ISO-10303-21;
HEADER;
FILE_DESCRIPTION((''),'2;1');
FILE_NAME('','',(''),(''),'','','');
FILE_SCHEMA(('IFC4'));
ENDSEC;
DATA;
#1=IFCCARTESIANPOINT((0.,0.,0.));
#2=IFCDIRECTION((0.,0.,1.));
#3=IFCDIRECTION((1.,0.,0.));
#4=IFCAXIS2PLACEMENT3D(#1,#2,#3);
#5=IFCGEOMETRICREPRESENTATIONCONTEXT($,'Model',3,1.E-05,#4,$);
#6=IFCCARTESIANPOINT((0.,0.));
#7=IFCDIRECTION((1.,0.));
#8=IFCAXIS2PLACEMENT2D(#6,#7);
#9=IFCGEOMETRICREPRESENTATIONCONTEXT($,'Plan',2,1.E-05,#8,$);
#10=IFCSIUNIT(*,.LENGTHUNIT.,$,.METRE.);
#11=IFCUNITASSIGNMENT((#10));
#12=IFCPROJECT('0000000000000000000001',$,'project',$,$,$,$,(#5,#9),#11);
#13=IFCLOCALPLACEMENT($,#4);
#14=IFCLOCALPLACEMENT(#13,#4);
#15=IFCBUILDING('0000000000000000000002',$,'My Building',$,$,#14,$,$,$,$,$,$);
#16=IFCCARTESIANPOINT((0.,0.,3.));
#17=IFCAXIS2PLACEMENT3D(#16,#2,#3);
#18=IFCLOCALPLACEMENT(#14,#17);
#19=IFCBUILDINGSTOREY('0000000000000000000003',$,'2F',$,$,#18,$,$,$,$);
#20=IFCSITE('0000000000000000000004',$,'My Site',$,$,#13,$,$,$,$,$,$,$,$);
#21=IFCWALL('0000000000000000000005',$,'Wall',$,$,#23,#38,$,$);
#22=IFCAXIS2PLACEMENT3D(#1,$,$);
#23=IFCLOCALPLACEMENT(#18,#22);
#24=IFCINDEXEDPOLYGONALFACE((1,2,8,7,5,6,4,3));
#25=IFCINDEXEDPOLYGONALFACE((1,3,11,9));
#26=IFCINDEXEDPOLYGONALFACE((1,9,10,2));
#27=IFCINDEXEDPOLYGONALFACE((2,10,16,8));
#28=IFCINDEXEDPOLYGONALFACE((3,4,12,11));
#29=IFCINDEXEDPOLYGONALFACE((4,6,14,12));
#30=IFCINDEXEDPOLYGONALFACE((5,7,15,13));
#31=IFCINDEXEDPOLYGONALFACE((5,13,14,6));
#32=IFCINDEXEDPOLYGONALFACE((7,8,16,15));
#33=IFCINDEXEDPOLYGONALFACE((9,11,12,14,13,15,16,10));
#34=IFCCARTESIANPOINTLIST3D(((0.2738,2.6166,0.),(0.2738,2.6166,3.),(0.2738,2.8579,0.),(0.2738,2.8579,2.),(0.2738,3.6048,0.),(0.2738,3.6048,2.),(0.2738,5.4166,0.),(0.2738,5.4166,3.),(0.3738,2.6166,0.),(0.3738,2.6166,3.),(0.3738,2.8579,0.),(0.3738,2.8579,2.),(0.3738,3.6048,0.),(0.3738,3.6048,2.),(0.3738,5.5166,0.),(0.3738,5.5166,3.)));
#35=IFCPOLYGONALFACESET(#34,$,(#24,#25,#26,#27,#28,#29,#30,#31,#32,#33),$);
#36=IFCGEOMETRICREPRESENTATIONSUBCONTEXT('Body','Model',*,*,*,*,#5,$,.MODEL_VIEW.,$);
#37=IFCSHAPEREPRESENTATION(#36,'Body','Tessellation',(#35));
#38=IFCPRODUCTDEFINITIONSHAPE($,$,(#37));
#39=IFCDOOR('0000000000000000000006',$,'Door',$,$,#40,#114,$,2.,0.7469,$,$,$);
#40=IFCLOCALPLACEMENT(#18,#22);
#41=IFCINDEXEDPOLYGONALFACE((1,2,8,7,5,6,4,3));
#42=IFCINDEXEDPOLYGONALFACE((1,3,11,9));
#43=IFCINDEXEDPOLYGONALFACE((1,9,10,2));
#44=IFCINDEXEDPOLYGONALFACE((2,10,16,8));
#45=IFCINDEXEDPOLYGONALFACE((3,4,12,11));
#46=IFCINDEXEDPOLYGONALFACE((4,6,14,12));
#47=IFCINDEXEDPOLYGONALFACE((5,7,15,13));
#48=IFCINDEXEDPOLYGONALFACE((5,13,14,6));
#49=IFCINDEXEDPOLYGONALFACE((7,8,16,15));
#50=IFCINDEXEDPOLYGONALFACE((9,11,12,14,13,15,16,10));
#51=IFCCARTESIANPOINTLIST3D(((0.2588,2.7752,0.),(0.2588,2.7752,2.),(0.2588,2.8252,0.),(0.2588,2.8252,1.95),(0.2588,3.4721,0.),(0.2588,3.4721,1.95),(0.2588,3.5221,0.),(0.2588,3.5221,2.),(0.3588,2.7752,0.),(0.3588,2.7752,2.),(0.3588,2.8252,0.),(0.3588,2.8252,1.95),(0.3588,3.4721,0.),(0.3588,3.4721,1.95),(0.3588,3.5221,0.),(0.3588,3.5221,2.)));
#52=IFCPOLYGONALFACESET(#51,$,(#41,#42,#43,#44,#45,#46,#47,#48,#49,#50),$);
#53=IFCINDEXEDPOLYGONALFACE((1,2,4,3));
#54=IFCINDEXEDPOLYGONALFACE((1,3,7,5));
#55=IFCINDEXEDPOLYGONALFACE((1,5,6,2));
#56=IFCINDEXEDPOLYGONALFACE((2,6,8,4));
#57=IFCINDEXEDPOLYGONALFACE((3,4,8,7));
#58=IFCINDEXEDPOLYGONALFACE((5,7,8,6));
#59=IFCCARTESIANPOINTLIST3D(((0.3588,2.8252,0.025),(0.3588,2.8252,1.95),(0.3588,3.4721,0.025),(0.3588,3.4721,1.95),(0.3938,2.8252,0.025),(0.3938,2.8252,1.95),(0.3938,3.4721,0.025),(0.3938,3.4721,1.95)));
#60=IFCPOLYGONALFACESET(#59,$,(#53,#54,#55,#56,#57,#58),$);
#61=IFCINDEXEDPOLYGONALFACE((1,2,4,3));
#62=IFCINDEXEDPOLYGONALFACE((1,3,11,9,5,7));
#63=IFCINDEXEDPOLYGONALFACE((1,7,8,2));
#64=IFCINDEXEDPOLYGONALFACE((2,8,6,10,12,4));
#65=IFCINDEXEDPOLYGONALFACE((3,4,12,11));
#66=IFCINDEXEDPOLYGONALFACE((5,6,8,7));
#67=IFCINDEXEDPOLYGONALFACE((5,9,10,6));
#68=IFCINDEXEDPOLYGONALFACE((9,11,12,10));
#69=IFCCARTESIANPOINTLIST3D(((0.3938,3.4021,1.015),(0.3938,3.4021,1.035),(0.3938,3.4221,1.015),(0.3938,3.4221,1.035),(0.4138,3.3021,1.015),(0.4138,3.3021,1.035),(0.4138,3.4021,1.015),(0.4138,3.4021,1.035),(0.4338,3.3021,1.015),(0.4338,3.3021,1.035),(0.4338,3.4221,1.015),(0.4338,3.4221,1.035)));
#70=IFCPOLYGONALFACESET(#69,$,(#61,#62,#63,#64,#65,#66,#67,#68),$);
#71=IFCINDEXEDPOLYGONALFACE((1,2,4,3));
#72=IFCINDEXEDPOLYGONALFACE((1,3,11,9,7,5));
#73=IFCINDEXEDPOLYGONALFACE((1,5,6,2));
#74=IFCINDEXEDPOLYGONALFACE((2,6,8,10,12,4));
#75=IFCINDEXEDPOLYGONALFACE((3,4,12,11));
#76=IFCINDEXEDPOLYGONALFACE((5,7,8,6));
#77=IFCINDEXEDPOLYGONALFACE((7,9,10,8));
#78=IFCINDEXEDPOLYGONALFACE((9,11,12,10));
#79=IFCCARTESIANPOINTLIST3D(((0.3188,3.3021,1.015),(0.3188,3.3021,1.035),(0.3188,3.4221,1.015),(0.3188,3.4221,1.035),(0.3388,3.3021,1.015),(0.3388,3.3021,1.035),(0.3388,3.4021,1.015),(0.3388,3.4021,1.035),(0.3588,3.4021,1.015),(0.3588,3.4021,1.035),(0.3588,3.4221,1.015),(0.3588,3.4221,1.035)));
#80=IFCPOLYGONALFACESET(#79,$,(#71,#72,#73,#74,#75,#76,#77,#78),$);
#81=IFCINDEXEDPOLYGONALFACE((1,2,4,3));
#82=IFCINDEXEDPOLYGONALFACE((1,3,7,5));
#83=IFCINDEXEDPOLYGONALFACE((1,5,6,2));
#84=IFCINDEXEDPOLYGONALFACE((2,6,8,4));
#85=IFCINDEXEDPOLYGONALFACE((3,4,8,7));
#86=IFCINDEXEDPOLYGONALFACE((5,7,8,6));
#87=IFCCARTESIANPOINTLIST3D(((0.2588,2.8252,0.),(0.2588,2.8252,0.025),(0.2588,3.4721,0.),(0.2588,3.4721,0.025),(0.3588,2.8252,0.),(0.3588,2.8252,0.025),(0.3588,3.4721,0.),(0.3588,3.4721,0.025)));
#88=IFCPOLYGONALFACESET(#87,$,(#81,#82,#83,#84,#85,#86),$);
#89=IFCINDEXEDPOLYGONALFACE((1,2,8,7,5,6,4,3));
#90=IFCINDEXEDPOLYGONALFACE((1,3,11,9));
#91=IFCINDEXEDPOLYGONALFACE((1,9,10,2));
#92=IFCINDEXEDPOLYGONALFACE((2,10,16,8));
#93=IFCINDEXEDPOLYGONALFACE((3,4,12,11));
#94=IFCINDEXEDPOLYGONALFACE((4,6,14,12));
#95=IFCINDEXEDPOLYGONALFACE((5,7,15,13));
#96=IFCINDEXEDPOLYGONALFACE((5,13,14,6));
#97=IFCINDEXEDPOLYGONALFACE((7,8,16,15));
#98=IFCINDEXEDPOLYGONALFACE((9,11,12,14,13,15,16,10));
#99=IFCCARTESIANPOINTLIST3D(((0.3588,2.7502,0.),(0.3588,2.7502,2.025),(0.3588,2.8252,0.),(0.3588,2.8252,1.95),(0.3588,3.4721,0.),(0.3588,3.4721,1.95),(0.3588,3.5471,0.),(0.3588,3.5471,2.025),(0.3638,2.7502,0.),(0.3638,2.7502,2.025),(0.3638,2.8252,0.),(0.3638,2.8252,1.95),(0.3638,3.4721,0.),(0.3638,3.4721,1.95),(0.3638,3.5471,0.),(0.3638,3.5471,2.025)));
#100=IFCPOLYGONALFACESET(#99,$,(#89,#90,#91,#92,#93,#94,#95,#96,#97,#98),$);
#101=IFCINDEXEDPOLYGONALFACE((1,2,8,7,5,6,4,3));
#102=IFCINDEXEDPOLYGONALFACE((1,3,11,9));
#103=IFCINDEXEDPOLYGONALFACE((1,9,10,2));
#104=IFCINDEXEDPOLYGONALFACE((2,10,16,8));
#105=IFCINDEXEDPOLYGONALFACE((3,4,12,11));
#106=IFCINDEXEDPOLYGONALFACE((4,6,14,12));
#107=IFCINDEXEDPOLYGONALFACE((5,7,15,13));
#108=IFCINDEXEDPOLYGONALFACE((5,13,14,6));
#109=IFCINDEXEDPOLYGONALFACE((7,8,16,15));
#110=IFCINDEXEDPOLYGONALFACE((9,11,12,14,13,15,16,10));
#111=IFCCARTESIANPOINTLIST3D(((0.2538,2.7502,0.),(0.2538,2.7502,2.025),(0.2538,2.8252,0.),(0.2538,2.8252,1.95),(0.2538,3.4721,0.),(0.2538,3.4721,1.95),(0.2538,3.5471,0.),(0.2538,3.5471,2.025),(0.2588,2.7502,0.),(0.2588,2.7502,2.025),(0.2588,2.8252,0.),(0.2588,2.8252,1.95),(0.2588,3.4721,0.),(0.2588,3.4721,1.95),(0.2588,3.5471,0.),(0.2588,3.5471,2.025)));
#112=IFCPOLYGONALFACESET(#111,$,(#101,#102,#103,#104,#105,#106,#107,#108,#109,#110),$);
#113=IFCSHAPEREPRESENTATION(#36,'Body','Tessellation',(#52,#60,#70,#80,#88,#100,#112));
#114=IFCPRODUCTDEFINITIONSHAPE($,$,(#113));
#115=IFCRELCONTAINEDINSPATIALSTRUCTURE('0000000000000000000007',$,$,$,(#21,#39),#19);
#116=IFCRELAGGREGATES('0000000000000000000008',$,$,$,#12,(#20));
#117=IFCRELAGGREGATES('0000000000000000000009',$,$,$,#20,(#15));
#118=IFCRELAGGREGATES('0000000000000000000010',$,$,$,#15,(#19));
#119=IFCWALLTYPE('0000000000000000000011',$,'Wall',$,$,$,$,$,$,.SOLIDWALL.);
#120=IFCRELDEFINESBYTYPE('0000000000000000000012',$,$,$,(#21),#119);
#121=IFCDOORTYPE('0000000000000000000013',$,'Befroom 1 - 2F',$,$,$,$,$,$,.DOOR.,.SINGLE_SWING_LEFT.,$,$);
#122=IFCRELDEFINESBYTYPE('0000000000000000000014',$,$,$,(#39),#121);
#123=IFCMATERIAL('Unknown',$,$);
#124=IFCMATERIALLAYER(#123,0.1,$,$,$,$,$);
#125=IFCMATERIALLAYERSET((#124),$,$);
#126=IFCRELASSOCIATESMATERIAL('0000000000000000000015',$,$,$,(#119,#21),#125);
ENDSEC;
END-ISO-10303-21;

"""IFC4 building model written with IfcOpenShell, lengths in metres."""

from ifc_helpers import new_model, entity, si_unit, frame, origin_with_axes, origin_2d_with_axis, place, context, subcontext, project, spatial, line, indexed_curve, outline, extrude, shape, source, transform, mapped, material, layer, layer_set, layer_usage, type_object, type_shapes, element, fill, save


model = new_model("IFC4")

# Units and contexts
model_context = context("Model", 3, precision=1e-05, world=origin_with_axes())
plan_context = context("Plan", 2, precision=1e-05, world=origin_2d_with_axis())
body_context_1 = subcontext(model_context, "Body", "Model", "MODEL_VIEW")
body_context_2 = subcontext(plan_context, "Body", "Plan", "PLAN_VIEW")
ifc_project = project(units=[si_unit("LENGTHUNIT", "METRE")], contexts=[model_context, plan_context])

# Site, building, storey
site_placement = place(None, origin_with_axes())
site = spatial("IfcSite", under=ifc_project, at=site_placement, Name="My Site")
building_placement = place(site_placement, origin_with_axes())
building = spatial("IfcBuilding", under=site, at=building_placement, Name="My Building")
storey_placement = place(building_placement, frame((0.0, 0.0, 3.0), z_axis=(0.0, 0.0, 1.0), x_axis=(1.0, 0.0, 0.0)))
storey = spatial("IfcBuildingStorey", under=building, at=storey_placement, Name="2F")

# Shared definitions
ifc_material = material(Name="Unknown")

# Shared definitions
ifc_layer_1 = layer(ifc_material, 0.1)
ifc_layer_set_1 = layer_set([ifc_layer_1])
wall_type = type_object("IfcWallType", Name="Wall", PredefinedType="SOLIDWALL", material=ifc_layer_set_1)

# Wall, opening, door
ifc_layer_usage_1 = layer_usage(ifc_layer_set_1, "AXIS2", "POSITIVE", 0.0)
wall_1_placement = place(storey_placement, frame((0.3738, 2.6166, 0.0), z_axis=(0.0, 0.0, 1.0), x_axis=(0.0, 1.0, 0.0)))
wall_1 = element("IfcWall", 1, at=wall_1_placement, inside=storey, type_object=wall_type, material=ifc_layer_usage_1, Name="Wall", context=body_context_1, shape_type="SweptSolid", body=[
    extrude(outline(indexed_curve([(0.0, 0.0), (0.0, 0.1), (2.8, 0.1), (2.9, 0.0)], segments=[line(1, 2, 3, 4, 1)])), origin_with_axes(), (0.0, 0.0, 1.0), 3.0),
])
shared_shape_1 = source(origin_with_axes(), body_context_1, "Body", "SweptSolid", [
    extrude(outline(indexed_curve([(0.0, 0.0), (0.7469, 0.0), (0.7469, 2.0), (0.0, 2.0)], segments=[line(1, 2, 3, 4, 1)])), frame((0.0, -0.6, 0.0), z_axis=(0.0, -1.0, 0.0), x_axis=(1.0, 0.0, 0.0)), (0.0, 0.0, -1.0), 1.2),
])
opening_1_placement = place(wall_1_placement, frame((0.9882, 0.21, 0.0), z_axis=(0.0, 0.0, 1.0), x_axis=(-1.0, 0.0, 0.0)))
opening_1 = element("IfcOpeningElement", 2, at=opening_1_placement, cuts=wall_1, PredefinedType="OPENING", context=body_context_1, shape_type="MappedRepresentation", body=[
    mapped(shared_shape_1, transform((0.0, 0.0, 0.0), x_axis=(1.0, 0.0, 0.0), y_axis=(0.0, 1.0, 0.0), z_axis=(0.0, 0.0, 1.0), scale=1.0)),
])
door_type_1 = type_object("IfcDoorType", Name="Befroom 1 - 2F", OperationType="SINGLE_SWING_LEFT", PredefinedType="DOOR")
shared_shape_2 = source(origin_with_axes(), body_context_1, "Body", "SweptSolid", [
    extrude(outline(indexed_curve([(0.0, 0.0), (0.0, 2.0), (0.7469, 2.0), (0.7469, 0.0), (0.6969, 0.0), (0.6969, 1.95), (0.05, 1.95), (0.05, 0.0)], segments=[line(1, 2, 3, 4, 5, 6, 7, 8, 1)])), frame((0.0, 0.0, 0.0), z_axis=(0.0, -1.0, 0.0), x_axis=(1.0, 0.0, 0.0)), (0.0, 0.0, -1.0), 0.1),
    extrude(outline(indexed_curve([(0.0, 0.0), (0.6469, 0.0), (0.6469, 0.035), (0.0, 0.035)], segments=[line(1, 2, 3, 4, 1)])), frame((0.05, -0.035, 0.025), z_axis=(0.0, 0.0, 1.0), x_axis=(1.0, 0.0, 0.0)), (0.0, 0.0, 1.0), 1.925),
    extrude(outline(indexed_curve([(0.0, 0.0), (0.0, -0.04), (-0.12, -0.04), (-0.12, -0.02), (-0.02, -0.02), (-0.02, 0.0)], segments=[line(1, 2, 3, 4, 5, 6, 1)])), frame((0.6469, -0.035, 1.015), z_axis=(0.0, 0.0, 1.0), x_axis=(1.0, 0.0, 0.0)), (0.0, 0.0, 1.0), 0.02),
    extrude(outline(indexed_curve([(0.0, 0.0), (0.0, 0.04), (-0.12, 0.04), (-0.12, 0.02), (-0.02, 0.02), (-0.02, 0.0)], segments=[line(1, 2, 3, 4, 5, 6, 1)])), frame((0.6469, 0.0, 1.015), z_axis=(0.0, 0.0, 1.0), x_axis=(1.0, 0.0, 0.0)), (0.0, 0.0, 1.0), 0.02),
    extrude(outline(indexed_curve([(0.0, 0.0), (0.6469, 0.0), (0.6469, 0.1), (0.0, 0.1)], segments=[line(1, 2, 3, 4, 1)])), frame((0.05, 0.0, 0.0), z_axis=(0.0, 0.0, 1.0), x_axis=(1.0, 0.0, 0.0)), (0.0, 0.0, 1.0), 0.025),
    extrude(outline(indexed_curve([(0.0, 0.0), (0.0, 2.025), (0.7969, 2.025), (0.7969, 0.0), (0.7219, 0.0), (0.7219, 1.95), (0.075, 1.95), (0.075, 0.0)], segments=[line(1, 2, 3, 4, 5, 6, 7, 8, 1)])), frame((-0.025, -0.005, 0.0), z_axis=(0.0, -1.0, 0.0), x_axis=(1.0, 0.0, 0.0)), (0.0, 0.0, -1.0), 0.005),
    extrude(outline(indexed_curve([(0.0, 0.0), (0.0, 2.025), (0.7969, 2.025), (0.7969, 0.0), (0.7219, 0.0), (0.7219, 1.95), (0.075, 1.95), (0.075, 0.0)], segments=[line(1, 2, 3, 4, 5, 6, 7, 8, 1)])), frame((-0.025, 0.1, 0.0), z_axis=(0.0, -1.0, 0.0), x_axis=(1.0, 0.0, 0.0)), (0.0, 0.0, -1.0), 0.005),
])
shared_shape_3 = source(origin_with_axes(), body_context_2, "Body", "Curve2D", [
    entity("IfcIndexedPolyCurve", entity("IfcCartesianPointList2D", [[0.0, 0.0], [0.05, 0.0], [0.05, 0.1], [0.0, 0.1]]), [entity("IfcLineIndex", [1, 2, 3, 4, 1])]),
    entity("IfcIndexedPolyCurve", entity("IfcCartesianPointList2D", [[0.7469, 0.0], [0.6969, 0.0], [0.6969, 0.1], [0.7469, 0.1]]), [entity("IfcLineIndex", [1, 2, 3, 4, 1])]),
    entity("IfcIndexedPolyCurve", entity("IfcCartesianPointList2D", [[-0.2734, -0.035], [0.3734, -0.035], [0.3734, 0.0], [-0.2734, 0.0]]), [entity("IfcLineIndex", [1, 2, 3, 4, 1])]),
])
type_shapes(door_type_1, [shared_shape_2, shared_shape_3])
door_1_placement = place(opening_1_placement, frame((0.8296, 0.195, 0.0), z_axis=(0.0, 0.0, 1.0), x_axis=(-1.0, 0.0, 0.0)))
door_1 = element("IfcDoor", 3, at=door_1_placement, inside=storey, type_object=door_type_1, Name="Door", OverallHeight=2.0, OverallWidth=0.7469, shapes=[
    shape(body_context_1, "Body", "MappedRepresentation", [mapped(shared_shape_2, transform((0.0, 0.0, 0.0), x_axis=(1.0, 0.0, 0.0), y_axis=(0.0, 1.0, 0.0), z_axis=(0.0, 0.0, 1.0), scale=1.0))]),
    shape(body_context_2, "Body", "MappedRepresentation", [mapped(shared_shape_3, transform((0.0, 0.0, 0.0), x_axis=(1.0, 0.0, 0.0), y_axis=(0.0, 1.0, 0.0), z_axis=(0.0, 0.0, 1.0), scale=1.0))]),
])
fill(opening_1, door_1)

save(model, "model.ifc")
